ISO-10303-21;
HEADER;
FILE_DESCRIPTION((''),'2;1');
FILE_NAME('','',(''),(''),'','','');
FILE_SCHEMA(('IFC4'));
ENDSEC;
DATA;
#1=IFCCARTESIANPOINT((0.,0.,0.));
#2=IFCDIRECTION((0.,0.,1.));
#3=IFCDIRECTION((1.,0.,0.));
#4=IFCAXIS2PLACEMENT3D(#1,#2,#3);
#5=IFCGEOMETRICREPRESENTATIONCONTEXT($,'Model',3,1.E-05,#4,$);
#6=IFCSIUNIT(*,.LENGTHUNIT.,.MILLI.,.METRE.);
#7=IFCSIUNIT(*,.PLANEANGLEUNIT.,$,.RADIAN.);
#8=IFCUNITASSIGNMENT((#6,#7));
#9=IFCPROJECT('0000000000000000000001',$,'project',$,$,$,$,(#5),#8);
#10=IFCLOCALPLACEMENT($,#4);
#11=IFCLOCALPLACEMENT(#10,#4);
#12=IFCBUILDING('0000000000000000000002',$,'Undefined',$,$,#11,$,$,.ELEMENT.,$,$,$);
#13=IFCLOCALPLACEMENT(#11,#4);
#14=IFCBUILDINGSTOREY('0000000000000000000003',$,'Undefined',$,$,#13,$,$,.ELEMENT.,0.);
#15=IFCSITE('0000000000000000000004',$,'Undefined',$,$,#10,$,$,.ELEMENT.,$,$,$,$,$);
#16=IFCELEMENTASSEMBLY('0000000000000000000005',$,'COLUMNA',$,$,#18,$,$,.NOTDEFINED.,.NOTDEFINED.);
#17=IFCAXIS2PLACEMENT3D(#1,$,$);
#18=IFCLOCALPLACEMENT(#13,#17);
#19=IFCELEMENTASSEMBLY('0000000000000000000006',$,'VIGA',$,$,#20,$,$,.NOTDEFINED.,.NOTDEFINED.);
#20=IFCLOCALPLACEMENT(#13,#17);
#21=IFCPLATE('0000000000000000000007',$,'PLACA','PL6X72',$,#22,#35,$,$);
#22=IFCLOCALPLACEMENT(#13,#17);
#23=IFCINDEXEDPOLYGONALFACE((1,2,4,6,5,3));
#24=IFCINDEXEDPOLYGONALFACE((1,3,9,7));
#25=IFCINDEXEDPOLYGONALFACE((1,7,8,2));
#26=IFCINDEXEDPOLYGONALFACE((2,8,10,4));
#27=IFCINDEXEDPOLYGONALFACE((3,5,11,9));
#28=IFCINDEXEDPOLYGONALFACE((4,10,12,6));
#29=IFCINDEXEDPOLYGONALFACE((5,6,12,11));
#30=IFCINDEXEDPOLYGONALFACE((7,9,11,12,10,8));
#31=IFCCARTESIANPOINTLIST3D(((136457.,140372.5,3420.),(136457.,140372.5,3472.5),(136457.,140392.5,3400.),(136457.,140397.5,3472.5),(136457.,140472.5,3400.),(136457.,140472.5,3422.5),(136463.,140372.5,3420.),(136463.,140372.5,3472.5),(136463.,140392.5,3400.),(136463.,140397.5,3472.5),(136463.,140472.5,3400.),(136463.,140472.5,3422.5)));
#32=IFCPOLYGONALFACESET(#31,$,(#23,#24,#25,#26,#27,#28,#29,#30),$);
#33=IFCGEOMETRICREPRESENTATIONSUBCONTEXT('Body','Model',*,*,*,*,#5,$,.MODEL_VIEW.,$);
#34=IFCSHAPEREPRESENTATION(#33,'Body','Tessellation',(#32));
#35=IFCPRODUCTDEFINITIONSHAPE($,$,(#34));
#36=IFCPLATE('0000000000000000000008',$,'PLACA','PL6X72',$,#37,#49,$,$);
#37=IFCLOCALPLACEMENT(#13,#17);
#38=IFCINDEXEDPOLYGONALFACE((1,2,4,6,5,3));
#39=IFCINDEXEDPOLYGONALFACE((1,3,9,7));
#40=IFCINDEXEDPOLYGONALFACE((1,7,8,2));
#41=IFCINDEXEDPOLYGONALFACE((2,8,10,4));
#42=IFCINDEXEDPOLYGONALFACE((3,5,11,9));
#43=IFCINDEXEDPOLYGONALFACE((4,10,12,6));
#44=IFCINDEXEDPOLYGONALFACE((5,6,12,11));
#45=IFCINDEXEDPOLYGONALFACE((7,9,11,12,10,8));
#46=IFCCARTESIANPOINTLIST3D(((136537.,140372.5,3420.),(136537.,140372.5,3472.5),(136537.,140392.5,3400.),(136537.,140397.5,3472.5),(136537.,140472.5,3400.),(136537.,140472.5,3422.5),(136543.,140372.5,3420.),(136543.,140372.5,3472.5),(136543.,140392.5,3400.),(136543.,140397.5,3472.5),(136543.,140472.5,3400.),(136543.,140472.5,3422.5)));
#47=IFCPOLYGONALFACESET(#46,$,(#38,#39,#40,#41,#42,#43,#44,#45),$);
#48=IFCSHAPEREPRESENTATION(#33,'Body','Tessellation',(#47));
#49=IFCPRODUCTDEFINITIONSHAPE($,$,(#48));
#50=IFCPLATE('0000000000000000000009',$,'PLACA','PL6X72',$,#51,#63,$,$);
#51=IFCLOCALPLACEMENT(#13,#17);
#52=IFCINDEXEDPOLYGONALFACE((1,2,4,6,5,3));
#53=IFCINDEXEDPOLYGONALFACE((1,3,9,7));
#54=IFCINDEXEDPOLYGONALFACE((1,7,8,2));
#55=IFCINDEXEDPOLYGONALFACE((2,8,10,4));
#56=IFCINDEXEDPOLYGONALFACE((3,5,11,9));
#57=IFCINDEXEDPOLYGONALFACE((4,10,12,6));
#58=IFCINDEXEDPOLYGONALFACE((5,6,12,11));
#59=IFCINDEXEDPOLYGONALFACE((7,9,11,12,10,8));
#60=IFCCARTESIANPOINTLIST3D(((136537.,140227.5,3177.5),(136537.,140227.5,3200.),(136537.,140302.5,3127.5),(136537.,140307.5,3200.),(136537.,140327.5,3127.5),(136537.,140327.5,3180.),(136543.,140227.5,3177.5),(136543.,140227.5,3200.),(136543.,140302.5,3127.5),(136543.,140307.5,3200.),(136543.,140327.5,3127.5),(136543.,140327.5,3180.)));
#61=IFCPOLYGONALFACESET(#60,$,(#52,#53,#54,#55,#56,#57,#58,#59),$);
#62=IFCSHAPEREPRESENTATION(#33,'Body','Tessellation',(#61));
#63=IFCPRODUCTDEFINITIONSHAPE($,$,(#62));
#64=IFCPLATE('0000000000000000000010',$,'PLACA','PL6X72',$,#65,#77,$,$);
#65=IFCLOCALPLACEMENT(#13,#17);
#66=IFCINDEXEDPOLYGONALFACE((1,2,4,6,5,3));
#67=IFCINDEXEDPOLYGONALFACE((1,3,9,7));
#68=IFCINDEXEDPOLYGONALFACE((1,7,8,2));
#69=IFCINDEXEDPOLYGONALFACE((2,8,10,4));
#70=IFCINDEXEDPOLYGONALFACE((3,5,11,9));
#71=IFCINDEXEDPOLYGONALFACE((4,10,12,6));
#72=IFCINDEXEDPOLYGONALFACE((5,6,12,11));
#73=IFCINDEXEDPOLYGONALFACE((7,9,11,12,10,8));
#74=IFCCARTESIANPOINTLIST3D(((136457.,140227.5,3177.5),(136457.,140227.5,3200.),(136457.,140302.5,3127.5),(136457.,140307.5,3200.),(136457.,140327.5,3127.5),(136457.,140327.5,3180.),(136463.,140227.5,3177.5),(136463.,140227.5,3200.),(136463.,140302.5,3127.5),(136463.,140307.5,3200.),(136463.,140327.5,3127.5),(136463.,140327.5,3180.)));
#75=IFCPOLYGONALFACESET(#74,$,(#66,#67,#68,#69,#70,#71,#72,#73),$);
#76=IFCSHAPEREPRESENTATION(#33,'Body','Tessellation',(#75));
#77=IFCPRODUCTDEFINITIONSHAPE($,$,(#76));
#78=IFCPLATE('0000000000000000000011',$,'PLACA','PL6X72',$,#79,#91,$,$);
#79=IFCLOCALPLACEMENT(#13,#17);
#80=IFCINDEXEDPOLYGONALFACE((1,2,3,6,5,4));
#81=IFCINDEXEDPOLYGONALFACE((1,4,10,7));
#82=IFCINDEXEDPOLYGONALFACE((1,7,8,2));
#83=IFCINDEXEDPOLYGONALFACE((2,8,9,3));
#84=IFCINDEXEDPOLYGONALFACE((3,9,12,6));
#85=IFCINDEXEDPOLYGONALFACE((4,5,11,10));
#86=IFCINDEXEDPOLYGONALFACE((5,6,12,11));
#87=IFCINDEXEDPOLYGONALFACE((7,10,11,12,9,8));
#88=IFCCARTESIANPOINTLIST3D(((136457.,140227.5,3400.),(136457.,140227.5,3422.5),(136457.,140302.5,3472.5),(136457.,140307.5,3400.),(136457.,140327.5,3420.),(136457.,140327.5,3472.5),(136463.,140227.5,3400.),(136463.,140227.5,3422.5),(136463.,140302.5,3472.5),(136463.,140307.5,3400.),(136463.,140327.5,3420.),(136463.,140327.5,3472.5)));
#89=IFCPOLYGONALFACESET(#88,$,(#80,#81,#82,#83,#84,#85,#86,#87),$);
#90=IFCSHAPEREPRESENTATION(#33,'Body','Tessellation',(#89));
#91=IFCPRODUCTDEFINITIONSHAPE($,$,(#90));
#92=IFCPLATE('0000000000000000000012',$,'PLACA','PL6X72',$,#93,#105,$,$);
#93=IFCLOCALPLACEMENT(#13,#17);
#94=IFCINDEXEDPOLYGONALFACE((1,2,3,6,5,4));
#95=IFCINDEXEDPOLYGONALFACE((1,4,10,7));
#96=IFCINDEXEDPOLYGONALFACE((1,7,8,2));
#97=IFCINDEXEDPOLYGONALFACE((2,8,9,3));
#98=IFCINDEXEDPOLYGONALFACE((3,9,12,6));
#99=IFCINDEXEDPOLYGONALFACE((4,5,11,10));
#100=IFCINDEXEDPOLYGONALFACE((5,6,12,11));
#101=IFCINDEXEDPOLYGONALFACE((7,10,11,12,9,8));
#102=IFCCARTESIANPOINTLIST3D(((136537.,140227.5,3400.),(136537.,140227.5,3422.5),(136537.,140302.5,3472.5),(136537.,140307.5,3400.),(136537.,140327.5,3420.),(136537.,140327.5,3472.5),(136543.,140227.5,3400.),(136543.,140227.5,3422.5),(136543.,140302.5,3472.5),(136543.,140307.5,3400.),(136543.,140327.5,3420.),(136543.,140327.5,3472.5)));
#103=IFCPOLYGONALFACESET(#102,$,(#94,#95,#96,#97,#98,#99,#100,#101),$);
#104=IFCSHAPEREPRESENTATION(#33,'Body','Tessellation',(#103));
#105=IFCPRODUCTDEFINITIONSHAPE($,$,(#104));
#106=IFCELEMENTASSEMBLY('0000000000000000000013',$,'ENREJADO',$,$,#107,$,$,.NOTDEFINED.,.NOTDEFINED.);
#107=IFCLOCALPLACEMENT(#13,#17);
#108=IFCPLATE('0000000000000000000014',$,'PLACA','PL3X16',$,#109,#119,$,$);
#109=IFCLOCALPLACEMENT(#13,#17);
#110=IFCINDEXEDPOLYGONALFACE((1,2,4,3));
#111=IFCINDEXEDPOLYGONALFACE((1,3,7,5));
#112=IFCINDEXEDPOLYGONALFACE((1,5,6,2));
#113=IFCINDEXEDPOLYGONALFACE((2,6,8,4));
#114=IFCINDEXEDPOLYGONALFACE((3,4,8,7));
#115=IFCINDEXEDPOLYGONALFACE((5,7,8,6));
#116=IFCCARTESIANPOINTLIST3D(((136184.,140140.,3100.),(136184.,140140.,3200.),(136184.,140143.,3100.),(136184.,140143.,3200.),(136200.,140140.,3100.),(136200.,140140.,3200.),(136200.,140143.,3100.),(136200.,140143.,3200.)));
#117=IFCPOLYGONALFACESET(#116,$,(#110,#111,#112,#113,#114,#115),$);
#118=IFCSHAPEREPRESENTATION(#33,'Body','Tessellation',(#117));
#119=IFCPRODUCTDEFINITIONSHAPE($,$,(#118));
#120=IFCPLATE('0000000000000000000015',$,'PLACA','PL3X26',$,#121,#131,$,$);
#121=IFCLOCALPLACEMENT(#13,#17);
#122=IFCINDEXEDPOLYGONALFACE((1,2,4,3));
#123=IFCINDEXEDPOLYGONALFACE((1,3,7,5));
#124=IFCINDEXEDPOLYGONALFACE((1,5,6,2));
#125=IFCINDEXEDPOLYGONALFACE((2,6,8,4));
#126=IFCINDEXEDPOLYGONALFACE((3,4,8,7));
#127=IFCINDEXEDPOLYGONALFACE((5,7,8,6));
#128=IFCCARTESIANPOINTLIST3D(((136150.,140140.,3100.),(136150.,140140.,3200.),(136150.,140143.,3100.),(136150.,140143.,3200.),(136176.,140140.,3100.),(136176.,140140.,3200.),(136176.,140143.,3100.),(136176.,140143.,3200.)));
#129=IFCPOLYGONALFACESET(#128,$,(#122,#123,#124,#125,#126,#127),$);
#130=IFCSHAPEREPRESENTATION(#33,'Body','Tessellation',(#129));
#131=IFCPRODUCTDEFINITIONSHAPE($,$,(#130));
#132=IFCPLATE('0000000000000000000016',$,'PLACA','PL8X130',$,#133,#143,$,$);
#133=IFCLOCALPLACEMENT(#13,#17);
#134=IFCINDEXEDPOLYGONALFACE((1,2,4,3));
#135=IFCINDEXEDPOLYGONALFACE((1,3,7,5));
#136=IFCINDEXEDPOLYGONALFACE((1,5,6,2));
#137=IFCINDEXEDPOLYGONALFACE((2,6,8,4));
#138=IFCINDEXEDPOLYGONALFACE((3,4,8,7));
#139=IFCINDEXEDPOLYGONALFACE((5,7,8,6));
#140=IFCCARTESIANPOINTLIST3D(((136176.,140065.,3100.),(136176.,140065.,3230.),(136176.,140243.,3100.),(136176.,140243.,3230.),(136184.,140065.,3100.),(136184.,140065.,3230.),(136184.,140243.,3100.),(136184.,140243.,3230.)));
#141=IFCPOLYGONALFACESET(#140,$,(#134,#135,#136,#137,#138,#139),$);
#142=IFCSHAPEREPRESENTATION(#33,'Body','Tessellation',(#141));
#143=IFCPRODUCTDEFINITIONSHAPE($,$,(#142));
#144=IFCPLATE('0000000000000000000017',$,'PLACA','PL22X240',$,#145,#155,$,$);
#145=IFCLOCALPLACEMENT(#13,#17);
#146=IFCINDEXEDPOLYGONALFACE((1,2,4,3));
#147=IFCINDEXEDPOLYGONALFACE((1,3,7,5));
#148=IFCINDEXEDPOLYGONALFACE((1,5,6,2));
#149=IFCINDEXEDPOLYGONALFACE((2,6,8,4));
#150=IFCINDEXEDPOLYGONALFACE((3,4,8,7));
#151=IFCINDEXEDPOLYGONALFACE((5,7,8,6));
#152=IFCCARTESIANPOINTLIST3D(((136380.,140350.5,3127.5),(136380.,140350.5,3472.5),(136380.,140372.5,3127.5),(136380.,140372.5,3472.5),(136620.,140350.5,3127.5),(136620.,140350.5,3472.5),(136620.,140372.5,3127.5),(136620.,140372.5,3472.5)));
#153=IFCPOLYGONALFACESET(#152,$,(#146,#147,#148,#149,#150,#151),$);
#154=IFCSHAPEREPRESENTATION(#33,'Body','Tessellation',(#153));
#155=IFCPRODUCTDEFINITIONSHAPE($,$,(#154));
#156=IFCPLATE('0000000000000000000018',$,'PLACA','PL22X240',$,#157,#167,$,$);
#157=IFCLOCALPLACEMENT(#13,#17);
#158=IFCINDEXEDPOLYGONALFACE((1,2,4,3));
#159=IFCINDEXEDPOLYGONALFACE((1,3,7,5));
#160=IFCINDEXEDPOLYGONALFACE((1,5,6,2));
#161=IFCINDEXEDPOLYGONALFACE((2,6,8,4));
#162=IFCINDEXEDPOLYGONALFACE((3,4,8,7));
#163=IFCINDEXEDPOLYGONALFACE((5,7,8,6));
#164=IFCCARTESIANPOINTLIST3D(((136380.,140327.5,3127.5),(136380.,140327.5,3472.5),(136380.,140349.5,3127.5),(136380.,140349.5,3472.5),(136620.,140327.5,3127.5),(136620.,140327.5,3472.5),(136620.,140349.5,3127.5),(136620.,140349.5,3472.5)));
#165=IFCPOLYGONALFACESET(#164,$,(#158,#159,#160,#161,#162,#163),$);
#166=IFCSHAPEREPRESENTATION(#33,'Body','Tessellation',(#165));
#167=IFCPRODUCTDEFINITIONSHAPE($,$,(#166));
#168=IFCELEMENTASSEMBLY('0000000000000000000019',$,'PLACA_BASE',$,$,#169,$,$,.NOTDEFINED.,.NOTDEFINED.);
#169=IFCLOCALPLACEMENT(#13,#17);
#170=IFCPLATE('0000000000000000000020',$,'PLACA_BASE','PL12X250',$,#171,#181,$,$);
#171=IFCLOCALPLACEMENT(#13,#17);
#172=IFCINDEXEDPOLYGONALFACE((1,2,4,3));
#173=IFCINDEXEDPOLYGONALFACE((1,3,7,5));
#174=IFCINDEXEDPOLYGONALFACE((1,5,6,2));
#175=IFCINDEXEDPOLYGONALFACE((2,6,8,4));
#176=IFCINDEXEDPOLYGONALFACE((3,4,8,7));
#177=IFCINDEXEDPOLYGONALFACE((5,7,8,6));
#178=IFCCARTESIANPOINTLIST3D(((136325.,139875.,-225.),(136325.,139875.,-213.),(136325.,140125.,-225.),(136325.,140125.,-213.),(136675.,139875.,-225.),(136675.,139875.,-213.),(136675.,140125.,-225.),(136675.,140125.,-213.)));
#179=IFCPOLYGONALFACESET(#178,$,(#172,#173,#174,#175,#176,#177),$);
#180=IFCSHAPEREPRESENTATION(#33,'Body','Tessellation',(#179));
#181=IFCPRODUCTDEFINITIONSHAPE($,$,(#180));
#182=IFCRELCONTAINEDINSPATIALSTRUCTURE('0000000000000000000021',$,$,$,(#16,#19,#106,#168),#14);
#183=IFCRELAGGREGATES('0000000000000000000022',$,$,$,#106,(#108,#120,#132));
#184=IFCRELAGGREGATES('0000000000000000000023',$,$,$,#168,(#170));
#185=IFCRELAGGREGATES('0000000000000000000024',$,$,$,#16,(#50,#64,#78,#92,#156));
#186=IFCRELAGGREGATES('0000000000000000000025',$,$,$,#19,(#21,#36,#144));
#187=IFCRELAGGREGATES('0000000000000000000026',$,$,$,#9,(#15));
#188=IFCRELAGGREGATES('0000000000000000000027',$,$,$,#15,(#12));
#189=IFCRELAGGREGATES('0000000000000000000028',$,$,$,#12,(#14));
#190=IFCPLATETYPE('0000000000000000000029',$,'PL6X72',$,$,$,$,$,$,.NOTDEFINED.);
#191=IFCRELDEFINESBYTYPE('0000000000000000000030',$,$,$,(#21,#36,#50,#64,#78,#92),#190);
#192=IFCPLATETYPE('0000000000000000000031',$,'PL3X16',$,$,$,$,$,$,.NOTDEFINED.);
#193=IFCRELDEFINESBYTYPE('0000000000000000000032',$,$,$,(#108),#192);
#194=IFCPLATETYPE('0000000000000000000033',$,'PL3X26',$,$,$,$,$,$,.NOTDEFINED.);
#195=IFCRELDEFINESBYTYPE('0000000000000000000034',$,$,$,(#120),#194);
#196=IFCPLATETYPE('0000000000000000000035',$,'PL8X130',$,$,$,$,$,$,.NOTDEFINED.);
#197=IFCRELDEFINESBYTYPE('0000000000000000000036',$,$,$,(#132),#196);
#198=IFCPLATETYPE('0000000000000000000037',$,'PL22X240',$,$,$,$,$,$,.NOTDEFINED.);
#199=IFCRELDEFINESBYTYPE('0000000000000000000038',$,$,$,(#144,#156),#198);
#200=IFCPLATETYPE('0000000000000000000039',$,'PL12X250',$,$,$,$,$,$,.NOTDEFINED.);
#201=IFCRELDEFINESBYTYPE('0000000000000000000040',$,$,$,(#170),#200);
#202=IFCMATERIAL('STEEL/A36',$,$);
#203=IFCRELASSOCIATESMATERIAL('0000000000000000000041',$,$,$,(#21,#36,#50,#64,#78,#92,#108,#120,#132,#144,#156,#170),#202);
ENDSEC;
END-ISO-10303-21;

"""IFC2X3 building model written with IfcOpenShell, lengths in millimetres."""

from ifc_helpers import new_model, si_unit, frame, origin_with_axes, place, context, subcontext, project, spatial, polyline, outline, extrude, material, type_object, element, aggregate, save


model = new_model("IFC2X3")

# Units and contexts
model_context = context("Model", 3, precision=1e-05, world=origin_with_axes())
body_context = subcontext(model_context, "Body", "Model", "MODEL_VIEW")
ifc_project = project(units=[si_unit("LENGTHUNIT", "METRE", prefix="MILLI"), si_unit("PLANEANGLEUNIT", "RADIAN")], contexts=[model_context])

# Site, building, storey
site_placement = place(None, origin_with_axes())
site = spatial("IfcSite", under=ifc_project, at=site_placement, Name="Undefined", CompositionType="ELEMENT")
building_placement = place(site_placement, origin_with_axes())
building = spatial("IfcBuilding", under=site, at=building_placement, Name="Undefined", CompositionType="ELEMENT")
storey_placement = place(building_placement, origin_with_axes())
storey = spatial("IfcBuildingStorey", under=building, at=storey_placement, Name="Undefined", CompositionType="ELEMENT", Elevation=0.0)

# Element assembly
assembly_1_placement = place(storey_placement, origin_with_axes())
assembly_1 = element("IfcElementAssembly", 1, at=assembly_1_placement, inside=storey, Name="COLUMNA", AssemblyPlace="NOTDEFINED", PredefinedType="NOTDEFINED")
ifc_material_1 = material(Name="STEEL/A36")

# Element assembly
assembly_2_placement = place(storey_placement, origin_with_axes())
assembly_2 = element("IfcElementAssembly", 2, at=assembly_2_placement, inside=storey, Name="VIGA", AssemblyPlace="NOTDEFINED", PredefinedType="NOTDEFINED")

# Plates
plate_type_1 = type_object("IfcPlateType", Name="PL6X72", PredefinedType="NOTDEFINED")
plate_1_placement = place(assembly_2_placement, frame((136460.0, 140372.5, 3472.5), z_axis=(-1.0, 0.0, 0.0), x_axis=(0.0, 1.0, 0.0)))
plate_1 = element("IfcPlate", 3, at=plate_1_placement, type_object=plate_type_1, material=ifc_material_1, Name="PLACA", Description="PL6X72", context=body_context, shape_type="SweptSolid", body=[
    extrude(outline(polyline([(0.0, 0.0), (25.0, 0.0), (100.0, 50.0), (100.0, 72.5), (20.0, 72.5), (0.0, 52.5), (0.0, 0.0)])), frame((0.0, 0.0, -3.0), z_axis=(0.0, 0.0, 1.0), x_axis=(1.0, 0.0, 0.0)), (0.0, 0.0, 1.0), 6.0),
])
plate_2_placement = place(assembly_2_placement, frame((136540.0, 140372.5, 3472.5), z_axis=(-1.0, 0.0, 0.0), x_axis=(0.0, 1.0, 0.0)))
plate_2 = element("IfcPlate", 4, at=plate_2_placement, type_object=plate_type_1, material=ifc_material_1, Name="PLACA", Description="PL6X72", context=body_context, shape_type="SweptSolid", body=[
    extrude(outline(polyline([(0.0, 0.0), (25.0, 0.0), (100.0, 50.0), (100.0, 72.5), (20.0, 72.5), (0.0, 52.5), (0.0, 0.0)])), frame((0.0, 0.0, -3.0), z_axis=(0.0, 0.0, 1.0), x_axis=(1.0, 0.0, 0.0)), (0.0, 0.0, 1.0), 6.0),
])
plate_3_placement = place(assembly_1_placement, frame((136540.0, 140327.5, 3127.5), z_axis=(-1.0, 0.0, 0.0), x_axis=(0.0, -1.0, 0.0)))
plate_3 = element("IfcPlate", 5, at=plate_3_placement, type_object=plate_type_1, material=ifc_material_1, Name="PLACA", Description="PL6X72", context=body_context, shape_type="SweptSolid", body=[
    extrude(outline(polyline([(0.0, 0.0), (25.0, 0.0), (100.0, 50.0), (100.0, 72.5), (20.0, 72.5), (0.0, 52.5), (0.0, 0.0)])), frame((0.0, 0.0, -3.0), z_axis=(0.0, 0.0, 1.0), x_axis=(1.0, 0.0, 0.0)), (0.0, 0.0, 1.0), 6.0),
])
plate_4_placement = place(assembly_1_placement, frame((136460.0, 140327.5, 3127.5), z_axis=(-1.0, 0.0, 0.0), x_axis=(0.0, -1.0, 0.0)))
plate_4 = element("IfcPlate", 6, at=plate_4_placement, type_object=plate_type_1, material=ifc_material_1, Name="PLACA", Description="PL6X72", context=body_context, shape_type="SweptSolid", body=[
    extrude(outline(polyline([(0.0, 0.0), (25.0, 0.0), (100.0, 50.0), (100.0, 72.5), (20.0, 72.5), (0.0, 52.5), (0.0, 0.0)])), frame((0.0, 0.0, -3.0), z_axis=(0.0, 0.0, 1.0), x_axis=(1.0, 0.0, 0.0)), (0.0, 0.0, 1.0), 6.0),
])
plate_5_placement = place(assembly_1_placement, frame((136460.0, 140327.5, 3472.5), z_axis=(1.0, 0.0, 0.0), x_axis=(0.0, -1.0, 0.0)))
plate_5 = element("IfcPlate", 7, at=plate_5_placement, type_object=plate_type_1, material=ifc_material_1, Name="PLACA", Description="PL6X72", context=body_context, shape_type="SweptSolid", body=[
    extrude(outline(polyline([(0.0, 0.0), (25.0, 0.0), (100.0, 50.0), (100.0, 72.5), (20.0, 72.5), (0.0, 52.5), (0.0, 0.0)])), frame((0.0, 0.0, -3.0), z_axis=(0.0, 0.0, 1.0), x_axis=(1.0, 0.0, 0.0)), (0.0, 0.0, 1.0), 6.0),
])
plate_6_placement = place(assembly_1_placement, frame((136540.0, 140327.5, 3472.5), z_axis=(1.0, 0.0, 0.0), x_axis=(0.0, -1.0, 0.0)))
plate_6 = element("IfcPlate", 8, at=plate_6_placement, type_object=plate_type_1, material=ifc_material_1, Name="PLACA", Description="PL6X72", context=body_context, shape_type="SweptSolid", body=[
    extrude(outline(polyline([(0.0, 0.0), (25.0, 0.0), (100.0, 50.0), (100.0, 72.5), (20.0, 72.5), (0.0, 52.5), (0.0, 0.0)])), frame((0.0, 0.0, -3.0), z_axis=(0.0, 0.0, 1.0), x_axis=(1.0, 0.0, 0.0)), (0.0, 0.0, 1.0), 6.0),
])

# Element assembly, plates
assembly_3_placement = place(storey_placement, origin_with_axes())
assembly_3 = element("IfcElementAssembly", 9, at=assembly_3_placement, inside=storey, Name="ENREJADO", AssemblyPlace="NOTDEFINED", PredefinedType="NOTDEFINED")
plate_type_2 = type_object("IfcPlateType", Name="PL3X16", PredefinedType="NOTDEFINED")
plate_7_placement = place(assembly_3_placement, frame((136200.0, 140141.5, 3100.0), z_axis=(0.000001, 1.0, 0.0), x_axis=(-1.0, 0.000001, 0.0)))
plate_7 = element("IfcPlate", 10, at=plate_7_placement, type_object=plate_type_2, material=ifc_material_1, Name="PLACA", Description="PL3X16", context=body_context, shape_type="SweptSolid", body=[
    extrude(outline(polyline([(0.0, 0.0), (16.0, 0.0), (16.0, 100.0), (0.0, 100.0), (0.0, 0.0)])), frame((0.0, 0.0, -1.5), z_axis=(0.0, 0.0, 1.0), x_axis=(1.0, 0.0, 0.0)), (0.0, 0.0, 1.0), 3.0),
])
plate_type_3 = type_object("IfcPlateType", Name="PL3X26", PredefinedType="NOTDEFINED")
plate_8_placement = place(assembly_3_placement, frame((136176.0, 140141.5, 3100.0), z_axis=(0.000001, 1.0, 0.0), x_axis=(-1.0, 0.000001, 0.0)))
plate_8 = element("IfcPlate", 11, at=plate_8_placement, type_object=plate_type_3, material=ifc_material_1, Name="PLACA", Description="PL3X26", context=body_context, shape_type="SweptSolid", body=[
    extrude(outline(polyline([(0.0, 0.0), (26.0, 0.0), (26.0, 100.0), (0.0, 100.0), (0.0, 0.0)])), frame((0.0, 0.0, -1.5), z_axis=(0.0, 0.0, 1.0), x_axis=(1.0, 0.0, 0.0)), (0.0, 0.0, 1.0), 3.0),
])
plate_type_4 = type_object("IfcPlateType", Name="PL8X130", PredefinedType="NOTDEFINED")
plate_9_placement = place(assembly_3_placement, frame((136180.0, 140065.0, 3165.0), z_axis=(-1.0, 0.000001, 0.0), x_axis=(0.000001, 1.0, 0.0)))
plate_9 = element("IfcPlate", 12, at=plate_9_placement, type_object=plate_type_4, material=ifc_material_1, Name="PLACA", Description="PL8X130", context=body_context, shape_type="SweptSolid", body=[
    extrude(outline(polyline([(0.0, -65.0), (0.0, 65.0), (178.0, 65.0), (178.0, -65.0), (0.0, -65.0)])), frame((0.0, 0.0, -4.0), z_axis=(0.0, 0.0, 1.0), x_axis=(1.0, 0.0, 0.0)), (0.0, 0.0, 1.0), 8.0),
])
aggregate(assembly_3, [plate_7, plate_8, plate_9])

# Plates
plate_type_5 = type_object("IfcPlateType", Name="PL22X240", PredefinedType="NOTDEFINED")
plate_10_placement = place(assembly_2_placement, frame((136500.0, 140361.5, 3127.5), z_axis=(0.0, 1.0, 0.0), x_axis=(0.0, 0.0, 1.0)))
plate_10 = element("IfcPlate", 13, at=plate_10_placement, type_object=plate_type_5, material=ifc_material_1, Name="PLACA", Description="PL22X240", context=body_context, shape_type="SweptSolid", body=[
    extrude(outline(polyline([(0.0, -120.0), (0.0, 120.0), (345.0, 120.0), (345.0, -120.0), (0.0, -120.0)])), frame((0.0, 0.0, -11.0), z_axis=(0.0, 0.0, 1.0), x_axis=(1.0, 0.0, 0.0)), (0.0, 0.0, 1.0), 22.0),
])
plate_11_placement = place(assembly_1_placement, frame((136500.0, 140338.5, 3127.5), z_axis=(0.0, 1.0, 0.0), x_axis=(0.0, 0.0, 1.0)))
plate_11 = element("IfcPlate", 14, at=plate_11_placement, type_object=plate_type_5, material=ifc_material_1, Name="PLACA", Description="PL22X240", context=body_context, shape_type="SweptSolid", body=[
    extrude(outline(polyline([(0.0, -120.0), (0.0, 120.0), (345.0, 120.0), (345.0, -120.0), (0.0, -120.0)])), frame((0.0, 0.0, -11.0), z_axis=(0.0, 0.0, 1.0), x_axis=(1.0, 0.0, 0.0)), (0.0, 0.0, 1.0), 22.0),
])

# Element assembly, plate
assembly_4_placement = place(storey_placement, origin_with_axes())
assembly_4 = element("IfcElementAssembly", 15, at=assembly_4_placement, inside=storey, Name="PLACA_BASE", AssemblyPlace="NOTDEFINED", PredefinedType="NOTDEFINED")
plate_type_6 = type_object("IfcPlateType", Name="PL12X250", PredefinedType="NOTDEFINED")
plate_12_placement = place(assembly_4_placement, frame((136325.0, 140000.0, -219.0), z_axis=(0.0, 0.0, 1.0), x_axis=(1.0, -0.000052, 0.0)))
plate_12 = element("IfcPlate", 16, at=plate_12_placement, type_object=plate_type_6, material=ifc_material_1, Name="PLACA_BASE", Description="PL12X250", context=body_context, shape_type="SweptSolid", body=[
    extrude(outline(polyline([(0.0, -125.0), (0.0, 125.0), (350.0, 125.0), (350.0, -125.0), (0.0, -125.0)])), frame((0.0, 0.0, -6.0), z_axis=(0.0, 0.0, 1.0), x_axis=(1.0, 0.0, 0.0)), (0.0, 0.0, 1.0), 12.0),
])
aggregate(assembly_4, [plate_12])

aggregate(assembly_1, [plate_3, plate_4, plate_5, plate_6, plate_11])
aggregate(assembly_2, [plate_1, plate_2, plate_10])

save(model, "model.ifc")
